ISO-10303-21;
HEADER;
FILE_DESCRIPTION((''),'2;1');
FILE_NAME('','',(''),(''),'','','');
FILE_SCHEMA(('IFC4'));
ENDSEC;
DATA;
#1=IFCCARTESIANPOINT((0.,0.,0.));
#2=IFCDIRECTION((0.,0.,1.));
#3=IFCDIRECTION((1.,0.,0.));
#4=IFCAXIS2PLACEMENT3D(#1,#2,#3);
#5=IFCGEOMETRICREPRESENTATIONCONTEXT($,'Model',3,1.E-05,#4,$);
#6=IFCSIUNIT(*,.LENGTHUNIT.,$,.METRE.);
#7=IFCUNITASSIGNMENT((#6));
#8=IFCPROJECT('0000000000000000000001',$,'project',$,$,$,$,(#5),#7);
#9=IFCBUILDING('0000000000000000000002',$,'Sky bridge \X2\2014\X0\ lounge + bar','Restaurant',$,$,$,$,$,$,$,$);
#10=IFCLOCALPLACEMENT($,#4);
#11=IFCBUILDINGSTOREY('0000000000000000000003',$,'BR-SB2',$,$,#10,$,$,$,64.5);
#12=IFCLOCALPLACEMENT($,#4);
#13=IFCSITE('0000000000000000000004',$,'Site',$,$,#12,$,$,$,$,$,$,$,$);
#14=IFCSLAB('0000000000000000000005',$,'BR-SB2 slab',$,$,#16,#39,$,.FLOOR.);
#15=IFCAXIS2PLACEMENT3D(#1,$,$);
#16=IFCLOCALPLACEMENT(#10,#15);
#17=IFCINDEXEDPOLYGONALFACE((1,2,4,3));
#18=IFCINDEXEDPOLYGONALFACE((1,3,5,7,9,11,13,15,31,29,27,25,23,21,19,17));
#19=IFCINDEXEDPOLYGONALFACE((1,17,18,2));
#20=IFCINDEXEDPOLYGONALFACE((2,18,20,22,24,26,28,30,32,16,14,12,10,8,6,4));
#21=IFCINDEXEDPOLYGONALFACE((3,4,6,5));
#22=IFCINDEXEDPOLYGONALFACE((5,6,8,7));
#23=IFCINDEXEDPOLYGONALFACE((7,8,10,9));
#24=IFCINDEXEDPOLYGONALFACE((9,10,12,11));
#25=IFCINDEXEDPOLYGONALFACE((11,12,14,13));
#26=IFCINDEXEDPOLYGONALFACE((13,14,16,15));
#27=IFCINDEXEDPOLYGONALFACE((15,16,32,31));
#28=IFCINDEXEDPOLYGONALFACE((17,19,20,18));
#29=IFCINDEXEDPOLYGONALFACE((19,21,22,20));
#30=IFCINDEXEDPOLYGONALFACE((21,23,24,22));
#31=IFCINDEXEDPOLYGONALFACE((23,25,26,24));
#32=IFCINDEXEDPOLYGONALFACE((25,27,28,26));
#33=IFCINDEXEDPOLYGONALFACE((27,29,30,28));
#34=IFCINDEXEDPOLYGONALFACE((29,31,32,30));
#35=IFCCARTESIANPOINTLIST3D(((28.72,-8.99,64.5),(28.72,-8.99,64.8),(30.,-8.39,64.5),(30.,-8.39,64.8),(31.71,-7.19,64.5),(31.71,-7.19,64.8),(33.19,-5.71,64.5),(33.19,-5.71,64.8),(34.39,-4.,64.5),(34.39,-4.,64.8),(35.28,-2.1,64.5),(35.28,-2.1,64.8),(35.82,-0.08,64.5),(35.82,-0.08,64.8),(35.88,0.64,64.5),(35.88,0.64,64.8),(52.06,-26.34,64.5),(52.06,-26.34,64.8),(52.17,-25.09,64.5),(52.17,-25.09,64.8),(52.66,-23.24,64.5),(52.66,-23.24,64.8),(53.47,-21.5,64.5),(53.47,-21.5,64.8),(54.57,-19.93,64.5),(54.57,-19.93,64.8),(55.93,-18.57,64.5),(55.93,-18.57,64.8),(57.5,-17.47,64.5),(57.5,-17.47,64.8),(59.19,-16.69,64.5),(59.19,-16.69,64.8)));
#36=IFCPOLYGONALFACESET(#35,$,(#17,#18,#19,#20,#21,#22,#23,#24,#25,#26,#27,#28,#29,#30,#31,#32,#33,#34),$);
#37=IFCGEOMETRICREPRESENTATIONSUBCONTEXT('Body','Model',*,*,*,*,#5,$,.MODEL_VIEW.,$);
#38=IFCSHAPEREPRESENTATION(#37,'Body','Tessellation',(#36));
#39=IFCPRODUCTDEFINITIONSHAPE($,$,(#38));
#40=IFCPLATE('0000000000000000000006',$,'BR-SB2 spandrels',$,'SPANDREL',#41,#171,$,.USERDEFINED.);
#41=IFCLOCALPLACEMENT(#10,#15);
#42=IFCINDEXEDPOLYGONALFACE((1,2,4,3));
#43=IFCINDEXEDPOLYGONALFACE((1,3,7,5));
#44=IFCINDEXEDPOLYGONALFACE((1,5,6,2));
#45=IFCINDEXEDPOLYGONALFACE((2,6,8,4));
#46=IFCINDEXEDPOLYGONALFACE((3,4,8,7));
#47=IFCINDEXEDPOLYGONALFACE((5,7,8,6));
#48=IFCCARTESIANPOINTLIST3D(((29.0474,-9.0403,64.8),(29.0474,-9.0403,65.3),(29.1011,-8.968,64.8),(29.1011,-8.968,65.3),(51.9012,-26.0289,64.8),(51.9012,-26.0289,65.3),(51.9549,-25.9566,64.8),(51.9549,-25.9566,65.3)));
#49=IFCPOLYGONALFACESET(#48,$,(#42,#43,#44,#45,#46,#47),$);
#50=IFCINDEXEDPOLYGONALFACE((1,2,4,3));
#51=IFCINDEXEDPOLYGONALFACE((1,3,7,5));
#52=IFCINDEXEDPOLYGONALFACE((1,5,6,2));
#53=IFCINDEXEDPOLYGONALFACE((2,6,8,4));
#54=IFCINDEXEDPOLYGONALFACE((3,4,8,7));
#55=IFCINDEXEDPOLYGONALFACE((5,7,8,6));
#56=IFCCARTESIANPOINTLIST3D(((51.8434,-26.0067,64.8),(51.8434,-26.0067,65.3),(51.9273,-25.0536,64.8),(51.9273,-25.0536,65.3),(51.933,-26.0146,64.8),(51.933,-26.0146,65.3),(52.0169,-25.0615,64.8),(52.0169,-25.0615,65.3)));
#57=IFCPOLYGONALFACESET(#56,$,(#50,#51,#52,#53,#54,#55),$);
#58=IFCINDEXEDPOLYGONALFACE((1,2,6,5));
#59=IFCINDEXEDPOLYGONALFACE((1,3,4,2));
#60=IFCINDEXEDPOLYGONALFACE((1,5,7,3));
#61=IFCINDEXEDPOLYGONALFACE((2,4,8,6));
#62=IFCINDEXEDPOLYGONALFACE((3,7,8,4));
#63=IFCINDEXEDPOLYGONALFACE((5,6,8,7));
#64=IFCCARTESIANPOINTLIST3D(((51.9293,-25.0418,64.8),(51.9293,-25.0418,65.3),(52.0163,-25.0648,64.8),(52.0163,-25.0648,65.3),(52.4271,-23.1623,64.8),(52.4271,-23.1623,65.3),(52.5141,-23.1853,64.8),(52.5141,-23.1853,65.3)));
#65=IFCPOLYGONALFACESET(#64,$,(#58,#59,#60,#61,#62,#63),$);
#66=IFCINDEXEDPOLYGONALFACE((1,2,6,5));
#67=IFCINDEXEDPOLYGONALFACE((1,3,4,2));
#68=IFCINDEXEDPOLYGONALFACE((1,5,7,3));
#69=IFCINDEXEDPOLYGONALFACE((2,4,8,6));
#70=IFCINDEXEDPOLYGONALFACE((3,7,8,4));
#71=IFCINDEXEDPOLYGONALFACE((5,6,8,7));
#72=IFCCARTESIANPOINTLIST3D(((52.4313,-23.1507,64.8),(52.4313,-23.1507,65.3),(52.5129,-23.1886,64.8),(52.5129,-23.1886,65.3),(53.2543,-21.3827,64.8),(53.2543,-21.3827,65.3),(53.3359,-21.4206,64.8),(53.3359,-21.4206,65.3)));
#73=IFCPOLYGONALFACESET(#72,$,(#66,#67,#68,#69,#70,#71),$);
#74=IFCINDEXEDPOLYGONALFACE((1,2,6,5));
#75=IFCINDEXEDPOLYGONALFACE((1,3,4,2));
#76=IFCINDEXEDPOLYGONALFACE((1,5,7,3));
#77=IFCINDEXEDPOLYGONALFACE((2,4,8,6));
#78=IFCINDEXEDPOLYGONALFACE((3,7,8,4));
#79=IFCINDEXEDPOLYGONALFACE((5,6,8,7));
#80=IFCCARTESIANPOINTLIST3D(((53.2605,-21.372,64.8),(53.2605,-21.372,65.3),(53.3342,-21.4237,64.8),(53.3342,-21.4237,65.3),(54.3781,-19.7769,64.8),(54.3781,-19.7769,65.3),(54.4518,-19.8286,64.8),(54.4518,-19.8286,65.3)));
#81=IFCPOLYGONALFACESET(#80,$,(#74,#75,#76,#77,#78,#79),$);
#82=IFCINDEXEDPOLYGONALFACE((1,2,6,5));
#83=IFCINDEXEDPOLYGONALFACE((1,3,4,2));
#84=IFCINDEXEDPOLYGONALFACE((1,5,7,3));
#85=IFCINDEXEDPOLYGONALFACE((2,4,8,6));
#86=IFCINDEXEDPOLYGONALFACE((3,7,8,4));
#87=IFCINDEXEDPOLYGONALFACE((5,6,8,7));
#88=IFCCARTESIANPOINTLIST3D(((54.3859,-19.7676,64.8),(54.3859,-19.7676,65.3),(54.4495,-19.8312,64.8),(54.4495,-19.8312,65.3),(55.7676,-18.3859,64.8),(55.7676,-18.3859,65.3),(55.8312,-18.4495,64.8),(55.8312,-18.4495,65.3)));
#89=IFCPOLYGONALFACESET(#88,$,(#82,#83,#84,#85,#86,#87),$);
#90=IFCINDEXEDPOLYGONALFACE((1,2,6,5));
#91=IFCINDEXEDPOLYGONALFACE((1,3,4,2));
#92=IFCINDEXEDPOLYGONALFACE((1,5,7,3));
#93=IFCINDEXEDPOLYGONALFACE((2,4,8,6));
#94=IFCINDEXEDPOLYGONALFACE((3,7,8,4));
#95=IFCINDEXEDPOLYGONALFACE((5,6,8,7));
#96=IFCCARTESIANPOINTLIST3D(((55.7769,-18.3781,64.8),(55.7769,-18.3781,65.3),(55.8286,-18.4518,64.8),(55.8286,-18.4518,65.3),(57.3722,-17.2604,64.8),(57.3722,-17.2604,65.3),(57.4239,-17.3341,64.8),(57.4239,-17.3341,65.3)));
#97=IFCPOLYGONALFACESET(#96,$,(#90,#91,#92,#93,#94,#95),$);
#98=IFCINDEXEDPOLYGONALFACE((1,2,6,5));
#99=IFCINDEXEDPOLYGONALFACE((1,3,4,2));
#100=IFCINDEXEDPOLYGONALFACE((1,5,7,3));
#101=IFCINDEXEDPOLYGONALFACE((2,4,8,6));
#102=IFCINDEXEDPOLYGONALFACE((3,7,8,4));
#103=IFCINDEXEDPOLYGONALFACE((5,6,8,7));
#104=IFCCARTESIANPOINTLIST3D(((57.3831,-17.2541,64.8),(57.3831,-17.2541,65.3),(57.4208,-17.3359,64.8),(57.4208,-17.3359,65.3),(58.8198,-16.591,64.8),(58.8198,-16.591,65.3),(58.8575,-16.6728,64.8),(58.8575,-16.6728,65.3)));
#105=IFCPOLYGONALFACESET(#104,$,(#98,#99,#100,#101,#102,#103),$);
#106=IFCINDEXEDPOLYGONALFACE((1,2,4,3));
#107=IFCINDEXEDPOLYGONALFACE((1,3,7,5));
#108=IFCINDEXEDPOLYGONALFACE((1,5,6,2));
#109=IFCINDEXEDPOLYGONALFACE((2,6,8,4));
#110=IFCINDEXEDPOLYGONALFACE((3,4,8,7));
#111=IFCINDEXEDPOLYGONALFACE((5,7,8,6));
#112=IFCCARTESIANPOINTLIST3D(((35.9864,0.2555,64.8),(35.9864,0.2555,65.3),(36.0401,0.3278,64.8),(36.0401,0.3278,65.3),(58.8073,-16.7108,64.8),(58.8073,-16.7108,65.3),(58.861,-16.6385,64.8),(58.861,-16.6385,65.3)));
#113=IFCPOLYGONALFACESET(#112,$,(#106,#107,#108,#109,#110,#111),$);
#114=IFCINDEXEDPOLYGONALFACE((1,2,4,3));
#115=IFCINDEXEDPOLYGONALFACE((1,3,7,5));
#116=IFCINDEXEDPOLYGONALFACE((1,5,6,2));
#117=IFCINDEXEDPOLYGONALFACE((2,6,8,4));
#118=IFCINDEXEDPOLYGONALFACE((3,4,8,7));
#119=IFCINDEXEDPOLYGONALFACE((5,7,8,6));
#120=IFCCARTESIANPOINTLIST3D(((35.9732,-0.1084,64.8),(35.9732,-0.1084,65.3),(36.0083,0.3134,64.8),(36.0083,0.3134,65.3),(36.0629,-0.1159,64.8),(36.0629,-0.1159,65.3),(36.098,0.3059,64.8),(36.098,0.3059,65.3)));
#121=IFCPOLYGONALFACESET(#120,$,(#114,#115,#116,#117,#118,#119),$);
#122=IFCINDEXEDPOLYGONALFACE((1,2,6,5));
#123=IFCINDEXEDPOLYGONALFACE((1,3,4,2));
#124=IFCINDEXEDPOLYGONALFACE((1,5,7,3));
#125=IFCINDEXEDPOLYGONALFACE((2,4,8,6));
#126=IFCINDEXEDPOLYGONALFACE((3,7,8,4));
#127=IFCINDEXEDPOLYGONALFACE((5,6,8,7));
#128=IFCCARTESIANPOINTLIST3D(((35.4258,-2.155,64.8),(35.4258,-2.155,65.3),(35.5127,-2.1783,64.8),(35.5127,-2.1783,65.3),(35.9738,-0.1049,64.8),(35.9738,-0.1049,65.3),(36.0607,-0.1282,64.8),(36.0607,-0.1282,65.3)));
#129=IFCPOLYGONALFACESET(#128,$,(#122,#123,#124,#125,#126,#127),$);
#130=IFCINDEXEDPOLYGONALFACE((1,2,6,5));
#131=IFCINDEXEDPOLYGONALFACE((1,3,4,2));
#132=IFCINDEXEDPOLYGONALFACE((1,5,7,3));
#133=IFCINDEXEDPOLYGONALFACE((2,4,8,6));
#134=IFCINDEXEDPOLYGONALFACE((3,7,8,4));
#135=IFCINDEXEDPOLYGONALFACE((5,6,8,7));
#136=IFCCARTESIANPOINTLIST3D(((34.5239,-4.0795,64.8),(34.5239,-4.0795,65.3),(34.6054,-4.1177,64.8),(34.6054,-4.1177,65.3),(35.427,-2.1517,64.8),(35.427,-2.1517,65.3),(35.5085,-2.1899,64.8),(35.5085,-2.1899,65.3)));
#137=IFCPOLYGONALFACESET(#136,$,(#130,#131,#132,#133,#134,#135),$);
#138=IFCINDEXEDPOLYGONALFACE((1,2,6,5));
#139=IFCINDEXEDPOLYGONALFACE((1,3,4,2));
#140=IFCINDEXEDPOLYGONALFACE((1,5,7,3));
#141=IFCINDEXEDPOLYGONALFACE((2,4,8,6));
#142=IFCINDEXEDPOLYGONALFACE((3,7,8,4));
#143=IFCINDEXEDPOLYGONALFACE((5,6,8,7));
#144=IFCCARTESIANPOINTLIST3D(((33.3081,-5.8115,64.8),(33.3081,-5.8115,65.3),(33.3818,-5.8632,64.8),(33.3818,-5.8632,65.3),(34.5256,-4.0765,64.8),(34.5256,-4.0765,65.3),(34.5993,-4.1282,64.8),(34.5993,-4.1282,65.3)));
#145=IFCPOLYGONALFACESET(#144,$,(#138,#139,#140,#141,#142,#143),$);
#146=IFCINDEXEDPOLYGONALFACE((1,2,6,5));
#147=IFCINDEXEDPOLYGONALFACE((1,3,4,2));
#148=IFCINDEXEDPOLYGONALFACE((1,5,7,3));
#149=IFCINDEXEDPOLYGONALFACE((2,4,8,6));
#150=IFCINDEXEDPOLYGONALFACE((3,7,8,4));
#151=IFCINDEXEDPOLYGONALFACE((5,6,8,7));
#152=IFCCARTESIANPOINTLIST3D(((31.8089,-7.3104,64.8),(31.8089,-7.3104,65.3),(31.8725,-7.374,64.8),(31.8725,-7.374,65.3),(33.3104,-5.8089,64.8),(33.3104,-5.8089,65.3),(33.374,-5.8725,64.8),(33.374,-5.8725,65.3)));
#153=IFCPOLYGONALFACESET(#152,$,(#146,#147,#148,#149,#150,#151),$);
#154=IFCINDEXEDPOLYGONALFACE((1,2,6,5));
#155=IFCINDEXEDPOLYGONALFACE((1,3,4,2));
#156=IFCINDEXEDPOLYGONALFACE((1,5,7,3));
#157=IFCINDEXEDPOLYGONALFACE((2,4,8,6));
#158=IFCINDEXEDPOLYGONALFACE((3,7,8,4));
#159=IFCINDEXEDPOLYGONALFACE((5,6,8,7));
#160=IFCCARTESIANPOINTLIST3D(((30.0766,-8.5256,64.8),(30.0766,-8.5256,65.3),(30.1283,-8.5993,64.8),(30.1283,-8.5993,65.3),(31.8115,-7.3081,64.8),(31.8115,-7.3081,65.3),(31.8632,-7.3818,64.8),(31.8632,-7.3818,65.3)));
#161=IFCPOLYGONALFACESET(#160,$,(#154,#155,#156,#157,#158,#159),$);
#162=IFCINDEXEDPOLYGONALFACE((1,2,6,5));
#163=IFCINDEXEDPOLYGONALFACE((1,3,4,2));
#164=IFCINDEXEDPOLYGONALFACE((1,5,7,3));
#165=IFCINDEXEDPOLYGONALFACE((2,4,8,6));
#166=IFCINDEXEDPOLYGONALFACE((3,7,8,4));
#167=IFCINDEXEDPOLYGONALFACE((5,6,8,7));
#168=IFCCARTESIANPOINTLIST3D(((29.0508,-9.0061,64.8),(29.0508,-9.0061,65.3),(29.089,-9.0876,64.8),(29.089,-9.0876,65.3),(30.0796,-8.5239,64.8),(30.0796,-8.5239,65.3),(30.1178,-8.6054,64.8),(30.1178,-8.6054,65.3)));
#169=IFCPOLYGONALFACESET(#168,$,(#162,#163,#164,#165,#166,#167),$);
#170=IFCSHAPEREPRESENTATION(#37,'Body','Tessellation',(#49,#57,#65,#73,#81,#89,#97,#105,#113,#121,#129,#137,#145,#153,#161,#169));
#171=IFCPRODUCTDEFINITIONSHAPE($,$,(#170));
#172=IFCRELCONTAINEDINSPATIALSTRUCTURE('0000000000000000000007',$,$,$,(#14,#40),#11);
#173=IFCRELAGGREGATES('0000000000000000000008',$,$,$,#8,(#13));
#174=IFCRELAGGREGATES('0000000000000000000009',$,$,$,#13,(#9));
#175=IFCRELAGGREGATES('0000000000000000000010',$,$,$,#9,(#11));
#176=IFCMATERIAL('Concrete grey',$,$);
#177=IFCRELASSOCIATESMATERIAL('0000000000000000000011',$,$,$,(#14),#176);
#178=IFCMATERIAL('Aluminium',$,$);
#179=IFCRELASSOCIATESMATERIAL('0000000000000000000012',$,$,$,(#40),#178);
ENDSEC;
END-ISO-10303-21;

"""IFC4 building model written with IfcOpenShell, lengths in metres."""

from ifc_helpers import new_model, si_unit, frame, origin_with_axes, place, context, subcontext, project, spatial, polyline, outline, extrude, material, element, save


model = new_model("IFC4")

# Units and contexts
model_context = context("Model", 3, precision=1e-05, world=origin_with_axes())
body_context = subcontext(model_context, "Body", "Model", "MODEL_VIEW")
ifc_project = project(units=[si_unit("LENGTHUNIT", "METRE")], contexts=[model_context])

# Site, building, storey
site_placement = place(None, origin_with_axes())
site = spatial("IfcSite", under=ifc_project, at=site_placement, Name="Site")
building = spatial("IfcBuilding", under=site, Name="Sky bridge — lounge + bar", Description="Restaurant")
storey_placement = place(None, origin_with_axes())
storey = spatial("IfcBuildingStorey", under=building, at=storey_placement, Name="BR-SB2", Elevation=64.5)

# Shared definitions
ifc_material_1 = material(Name="Aluminium")

# Slab
ifc_material_2 = material(Name="Concrete grey")
slab_placement = place(storey_placement, origin_with_axes())
element("IfcSlab", 1, at=slab_placement, inside=storey, material=ifc_material_2, Name="BR-SB2 slab", PredefinedType="FLOOR", context=body_context, shape_type="SweptSolid", body=[
    extrude(outline(polyline([(28.72, -8.99), (52.06, -26.34), (52.17, -25.09), (52.66, -23.24), (53.47, -21.5), (54.57, -19.93), (55.93, -18.57), (57.5, -17.47), (59.19, -16.69), (35.88, 0.64), (35.82, -0.08), (35.28, -2.1), (34.39, -4.0), (33.19, -5.71), (31.71, -7.19), (30.0, -8.39), (28.72, -8.99)])), frame((0.0, 0.0, 64.5), z_axis=(0.0, 0.0, 1.0), x_axis=(1.0, 0.0, 0.0)), (0.0, 0.0, 1.0), 0.3),
])

# Plate
plate_placement = place(storey_placement, origin_with_axes())
element("IfcPlate", 2, at=plate_placement, inside=storey, material=ifc_material_1, Name="BR-SB2 spandrels", ObjectType="SPANDREL", PredefinedType="USERDEFINED", context=body_context, shape_type="SweptSolid", body=[
    extrude(outline(polyline([(29.0474, -9.0403), (51.9012, -26.0289), (51.9549, -25.9566), (29.1011, -8.968), (29.0474, -9.0403)])), frame((0.0, 0.0, 64.8), z_axis=(0.0, 0.0, 1.0), x_axis=(1.0, 0.0, 0.0)), (0.0, 0.0, 1.0), 0.5),
    extrude(outline(polyline([(51.933, -26.0146), (52.0169, -25.0615), (51.9273, -25.0536), (51.8434, -26.0067), (51.933, -26.0146)])), frame((0.0, 0.0, 64.8), z_axis=(0.0, 0.0, 1.0), x_axis=(1.0, 0.0, 0.0)), (0.0, 0.0, 1.0), 0.5),
    extrude(outline(polyline([(52.0163, -25.0648), (52.5141, -23.1853), (52.4271, -23.1623), (51.9293, -25.0418), (52.0163, -25.0648)])), frame((0.0, 0.0, 64.8), z_axis=(0.0, 0.0, 1.0), x_axis=(1.0, 0.0, 0.0)), (0.0, 0.0, 1.0), 0.5),
    extrude(outline(polyline([(52.5129, -23.1886), (53.3359, -21.4206), (53.2543, -21.3827), (52.4313, -23.1507), (52.5129, -23.1886)])), frame((0.0, 0.0, 64.8), z_axis=(0.0, 0.0, 1.0), x_axis=(1.0, 0.0, 0.0)), (0.0, 0.0, 1.0), 0.5),
    extrude(outline(polyline([(53.3342, -21.4237), (54.4518, -19.8286), (54.3781, -19.7769), (53.2605, -21.372), (53.3342, -21.4237)])), frame((0.0, 0.0, 64.8), z_axis=(0.0, 0.0, 1.0), x_axis=(1.0, 0.0, 0.0)), (0.0, 0.0, 1.0), 0.5),
    extrude(outline(polyline([(54.4495, -19.8312), (55.8312, -18.4495), (55.7676, -18.3859), (54.3859, -19.7676), (54.4495, -19.8312)])), frame((0.0, 0.0, 64.8), z_axis=(0.0, 0.0, 1.0), x_axis=(1.0, 0.0, 0.0)), (0.0, 0.0, 1.0), 0.5),
    extrude(outline(polyline([(55.8286, -18.4518), (57.4239, -17.3341), (57.3722, -17.2604), (55.7769, -18.3781), (55.8286, -18.4518)])), frame((0.0, 0.0, 64.8), z_axis=(0.0, 0.0, 1.0), x_axis=(1.0, 0.0, 0.0)), (0.0, 0.0, 1.0), 0.5),
    extrude(outline(polyline([(57.4208, -17.3359), (58.8575, -16.6728), (58.8198, -16.591), (57.3831, -17.2541), (57.4208, -17.3359)])), frame((0.0, 0.0, 64.8), z_axis=(0.0, 0.0, 1.0), x_axis=(1.0, 0.0, 0.0)), (0.0, 0.0, 1.0), 0.5),
    extrude(outline(polyline([(58.861, -16.6385), (36.0401, 0.3278), (35.9864, 0.2555), (58.8073, -16.7108), (58.861, -16.6385)])), frame((0.0, 0.0, 64.8), z_axis=(0.0, 0.0, 1.0), x_axis=(1.0, 0.0, 0.0)), (0.0, 0.0, 1.0), 0.5),
    extrude(outline(polyline([(36.0083, 0.3134), (35.9732, -0.1084), (36.0629, -0.1159), (36.098, 0.3059), (36.0083, 0.3134)])), frame((0.0, 0.0, 64.8), z_axis=(0.0, 0.0, 1.0), x_axis=(1.0, 0.0, 0.0)), (0.0, 0.0, 1.0), 0.5),
    extrude(outline(polyline([(35.9738, -0.1049), (35.4258, -2.155), (35.5127, -2.1783), (36.0607, -0.1282), (35.9738, -0.1049)])), frame((0.0, 0.0, 64.8), z_axis=(0.0, 0.0, 1.0), x_axis=(1.0, 0.0, 0.0)), (0.0, 0.0, 1.0), 0.5),
    extrude(outline(polyline([(35.427, -2.1517), (34.5239, -4.0795), (34.6054, -4.1177), (35.5085, -2.1899), (35.427, -2.1517)])), frame((0.0, 0.0, 64.8), z_axis=(0.0, 0.0, 1.0), x_axis=(1.0, 0.0, 0.0)), (0.0, 0.0, 1.0), 0.5),
    extrude(outline(polyline([(34.5256, -4.0765), (33.3081, -5.8115), (33.3818, -5.8632), (34.5993, -4.1282), (34.5256, -4.0765)])), frame((0.0, 0.0, 64.8), z_axis=(0.0, 0.0, 1.0), x_axis=(1.0, 0.0, 0.0)), (0.0, 0.0, 1.0), 0.5),
    extrude(outline(polyline([(33.3104, -5.8089), (31.8089, -7.3104), (31.8725, -7.374), (33.374, -5.8725), (33.3104, -5.8089)])), frame((0.0, 0.0, 64.8), z_axis=(0.0, 0.0, 1.0), x_axis=(1.0, 0.0, 0.0)), (0.0, 0.0, 1.0), 0.5),
    extrude(outline(polyline([(31.8115, -7.3081), (30.0766, -8.5256), (30.1283, -8.5993), (31.8632, -7.3818), (31.8115, -7.3081)])), frame((0.0, 0.0, 64.8), z_axis=(0.0, 0.0, 1.0), x_axis=(1.0, 0.0, 0.0)), (0.0, 0.0, 1.0), 0.5),
    extrude(outline(polyline([(30.0796, -8.5239), (29.0508, -9.0061), (29.089, -9.0876), (30.1178, -8.6054), (30.0796, -8.5239)])), frame((0.0, 0.0, 64.8), z_axis=(0.0, 0.0, 1.0), x_axis=(1.0, 0.0, 0.0)), (0.0, 0.0, 1.0), 0.5),
])

save(model, "model.ifc")
